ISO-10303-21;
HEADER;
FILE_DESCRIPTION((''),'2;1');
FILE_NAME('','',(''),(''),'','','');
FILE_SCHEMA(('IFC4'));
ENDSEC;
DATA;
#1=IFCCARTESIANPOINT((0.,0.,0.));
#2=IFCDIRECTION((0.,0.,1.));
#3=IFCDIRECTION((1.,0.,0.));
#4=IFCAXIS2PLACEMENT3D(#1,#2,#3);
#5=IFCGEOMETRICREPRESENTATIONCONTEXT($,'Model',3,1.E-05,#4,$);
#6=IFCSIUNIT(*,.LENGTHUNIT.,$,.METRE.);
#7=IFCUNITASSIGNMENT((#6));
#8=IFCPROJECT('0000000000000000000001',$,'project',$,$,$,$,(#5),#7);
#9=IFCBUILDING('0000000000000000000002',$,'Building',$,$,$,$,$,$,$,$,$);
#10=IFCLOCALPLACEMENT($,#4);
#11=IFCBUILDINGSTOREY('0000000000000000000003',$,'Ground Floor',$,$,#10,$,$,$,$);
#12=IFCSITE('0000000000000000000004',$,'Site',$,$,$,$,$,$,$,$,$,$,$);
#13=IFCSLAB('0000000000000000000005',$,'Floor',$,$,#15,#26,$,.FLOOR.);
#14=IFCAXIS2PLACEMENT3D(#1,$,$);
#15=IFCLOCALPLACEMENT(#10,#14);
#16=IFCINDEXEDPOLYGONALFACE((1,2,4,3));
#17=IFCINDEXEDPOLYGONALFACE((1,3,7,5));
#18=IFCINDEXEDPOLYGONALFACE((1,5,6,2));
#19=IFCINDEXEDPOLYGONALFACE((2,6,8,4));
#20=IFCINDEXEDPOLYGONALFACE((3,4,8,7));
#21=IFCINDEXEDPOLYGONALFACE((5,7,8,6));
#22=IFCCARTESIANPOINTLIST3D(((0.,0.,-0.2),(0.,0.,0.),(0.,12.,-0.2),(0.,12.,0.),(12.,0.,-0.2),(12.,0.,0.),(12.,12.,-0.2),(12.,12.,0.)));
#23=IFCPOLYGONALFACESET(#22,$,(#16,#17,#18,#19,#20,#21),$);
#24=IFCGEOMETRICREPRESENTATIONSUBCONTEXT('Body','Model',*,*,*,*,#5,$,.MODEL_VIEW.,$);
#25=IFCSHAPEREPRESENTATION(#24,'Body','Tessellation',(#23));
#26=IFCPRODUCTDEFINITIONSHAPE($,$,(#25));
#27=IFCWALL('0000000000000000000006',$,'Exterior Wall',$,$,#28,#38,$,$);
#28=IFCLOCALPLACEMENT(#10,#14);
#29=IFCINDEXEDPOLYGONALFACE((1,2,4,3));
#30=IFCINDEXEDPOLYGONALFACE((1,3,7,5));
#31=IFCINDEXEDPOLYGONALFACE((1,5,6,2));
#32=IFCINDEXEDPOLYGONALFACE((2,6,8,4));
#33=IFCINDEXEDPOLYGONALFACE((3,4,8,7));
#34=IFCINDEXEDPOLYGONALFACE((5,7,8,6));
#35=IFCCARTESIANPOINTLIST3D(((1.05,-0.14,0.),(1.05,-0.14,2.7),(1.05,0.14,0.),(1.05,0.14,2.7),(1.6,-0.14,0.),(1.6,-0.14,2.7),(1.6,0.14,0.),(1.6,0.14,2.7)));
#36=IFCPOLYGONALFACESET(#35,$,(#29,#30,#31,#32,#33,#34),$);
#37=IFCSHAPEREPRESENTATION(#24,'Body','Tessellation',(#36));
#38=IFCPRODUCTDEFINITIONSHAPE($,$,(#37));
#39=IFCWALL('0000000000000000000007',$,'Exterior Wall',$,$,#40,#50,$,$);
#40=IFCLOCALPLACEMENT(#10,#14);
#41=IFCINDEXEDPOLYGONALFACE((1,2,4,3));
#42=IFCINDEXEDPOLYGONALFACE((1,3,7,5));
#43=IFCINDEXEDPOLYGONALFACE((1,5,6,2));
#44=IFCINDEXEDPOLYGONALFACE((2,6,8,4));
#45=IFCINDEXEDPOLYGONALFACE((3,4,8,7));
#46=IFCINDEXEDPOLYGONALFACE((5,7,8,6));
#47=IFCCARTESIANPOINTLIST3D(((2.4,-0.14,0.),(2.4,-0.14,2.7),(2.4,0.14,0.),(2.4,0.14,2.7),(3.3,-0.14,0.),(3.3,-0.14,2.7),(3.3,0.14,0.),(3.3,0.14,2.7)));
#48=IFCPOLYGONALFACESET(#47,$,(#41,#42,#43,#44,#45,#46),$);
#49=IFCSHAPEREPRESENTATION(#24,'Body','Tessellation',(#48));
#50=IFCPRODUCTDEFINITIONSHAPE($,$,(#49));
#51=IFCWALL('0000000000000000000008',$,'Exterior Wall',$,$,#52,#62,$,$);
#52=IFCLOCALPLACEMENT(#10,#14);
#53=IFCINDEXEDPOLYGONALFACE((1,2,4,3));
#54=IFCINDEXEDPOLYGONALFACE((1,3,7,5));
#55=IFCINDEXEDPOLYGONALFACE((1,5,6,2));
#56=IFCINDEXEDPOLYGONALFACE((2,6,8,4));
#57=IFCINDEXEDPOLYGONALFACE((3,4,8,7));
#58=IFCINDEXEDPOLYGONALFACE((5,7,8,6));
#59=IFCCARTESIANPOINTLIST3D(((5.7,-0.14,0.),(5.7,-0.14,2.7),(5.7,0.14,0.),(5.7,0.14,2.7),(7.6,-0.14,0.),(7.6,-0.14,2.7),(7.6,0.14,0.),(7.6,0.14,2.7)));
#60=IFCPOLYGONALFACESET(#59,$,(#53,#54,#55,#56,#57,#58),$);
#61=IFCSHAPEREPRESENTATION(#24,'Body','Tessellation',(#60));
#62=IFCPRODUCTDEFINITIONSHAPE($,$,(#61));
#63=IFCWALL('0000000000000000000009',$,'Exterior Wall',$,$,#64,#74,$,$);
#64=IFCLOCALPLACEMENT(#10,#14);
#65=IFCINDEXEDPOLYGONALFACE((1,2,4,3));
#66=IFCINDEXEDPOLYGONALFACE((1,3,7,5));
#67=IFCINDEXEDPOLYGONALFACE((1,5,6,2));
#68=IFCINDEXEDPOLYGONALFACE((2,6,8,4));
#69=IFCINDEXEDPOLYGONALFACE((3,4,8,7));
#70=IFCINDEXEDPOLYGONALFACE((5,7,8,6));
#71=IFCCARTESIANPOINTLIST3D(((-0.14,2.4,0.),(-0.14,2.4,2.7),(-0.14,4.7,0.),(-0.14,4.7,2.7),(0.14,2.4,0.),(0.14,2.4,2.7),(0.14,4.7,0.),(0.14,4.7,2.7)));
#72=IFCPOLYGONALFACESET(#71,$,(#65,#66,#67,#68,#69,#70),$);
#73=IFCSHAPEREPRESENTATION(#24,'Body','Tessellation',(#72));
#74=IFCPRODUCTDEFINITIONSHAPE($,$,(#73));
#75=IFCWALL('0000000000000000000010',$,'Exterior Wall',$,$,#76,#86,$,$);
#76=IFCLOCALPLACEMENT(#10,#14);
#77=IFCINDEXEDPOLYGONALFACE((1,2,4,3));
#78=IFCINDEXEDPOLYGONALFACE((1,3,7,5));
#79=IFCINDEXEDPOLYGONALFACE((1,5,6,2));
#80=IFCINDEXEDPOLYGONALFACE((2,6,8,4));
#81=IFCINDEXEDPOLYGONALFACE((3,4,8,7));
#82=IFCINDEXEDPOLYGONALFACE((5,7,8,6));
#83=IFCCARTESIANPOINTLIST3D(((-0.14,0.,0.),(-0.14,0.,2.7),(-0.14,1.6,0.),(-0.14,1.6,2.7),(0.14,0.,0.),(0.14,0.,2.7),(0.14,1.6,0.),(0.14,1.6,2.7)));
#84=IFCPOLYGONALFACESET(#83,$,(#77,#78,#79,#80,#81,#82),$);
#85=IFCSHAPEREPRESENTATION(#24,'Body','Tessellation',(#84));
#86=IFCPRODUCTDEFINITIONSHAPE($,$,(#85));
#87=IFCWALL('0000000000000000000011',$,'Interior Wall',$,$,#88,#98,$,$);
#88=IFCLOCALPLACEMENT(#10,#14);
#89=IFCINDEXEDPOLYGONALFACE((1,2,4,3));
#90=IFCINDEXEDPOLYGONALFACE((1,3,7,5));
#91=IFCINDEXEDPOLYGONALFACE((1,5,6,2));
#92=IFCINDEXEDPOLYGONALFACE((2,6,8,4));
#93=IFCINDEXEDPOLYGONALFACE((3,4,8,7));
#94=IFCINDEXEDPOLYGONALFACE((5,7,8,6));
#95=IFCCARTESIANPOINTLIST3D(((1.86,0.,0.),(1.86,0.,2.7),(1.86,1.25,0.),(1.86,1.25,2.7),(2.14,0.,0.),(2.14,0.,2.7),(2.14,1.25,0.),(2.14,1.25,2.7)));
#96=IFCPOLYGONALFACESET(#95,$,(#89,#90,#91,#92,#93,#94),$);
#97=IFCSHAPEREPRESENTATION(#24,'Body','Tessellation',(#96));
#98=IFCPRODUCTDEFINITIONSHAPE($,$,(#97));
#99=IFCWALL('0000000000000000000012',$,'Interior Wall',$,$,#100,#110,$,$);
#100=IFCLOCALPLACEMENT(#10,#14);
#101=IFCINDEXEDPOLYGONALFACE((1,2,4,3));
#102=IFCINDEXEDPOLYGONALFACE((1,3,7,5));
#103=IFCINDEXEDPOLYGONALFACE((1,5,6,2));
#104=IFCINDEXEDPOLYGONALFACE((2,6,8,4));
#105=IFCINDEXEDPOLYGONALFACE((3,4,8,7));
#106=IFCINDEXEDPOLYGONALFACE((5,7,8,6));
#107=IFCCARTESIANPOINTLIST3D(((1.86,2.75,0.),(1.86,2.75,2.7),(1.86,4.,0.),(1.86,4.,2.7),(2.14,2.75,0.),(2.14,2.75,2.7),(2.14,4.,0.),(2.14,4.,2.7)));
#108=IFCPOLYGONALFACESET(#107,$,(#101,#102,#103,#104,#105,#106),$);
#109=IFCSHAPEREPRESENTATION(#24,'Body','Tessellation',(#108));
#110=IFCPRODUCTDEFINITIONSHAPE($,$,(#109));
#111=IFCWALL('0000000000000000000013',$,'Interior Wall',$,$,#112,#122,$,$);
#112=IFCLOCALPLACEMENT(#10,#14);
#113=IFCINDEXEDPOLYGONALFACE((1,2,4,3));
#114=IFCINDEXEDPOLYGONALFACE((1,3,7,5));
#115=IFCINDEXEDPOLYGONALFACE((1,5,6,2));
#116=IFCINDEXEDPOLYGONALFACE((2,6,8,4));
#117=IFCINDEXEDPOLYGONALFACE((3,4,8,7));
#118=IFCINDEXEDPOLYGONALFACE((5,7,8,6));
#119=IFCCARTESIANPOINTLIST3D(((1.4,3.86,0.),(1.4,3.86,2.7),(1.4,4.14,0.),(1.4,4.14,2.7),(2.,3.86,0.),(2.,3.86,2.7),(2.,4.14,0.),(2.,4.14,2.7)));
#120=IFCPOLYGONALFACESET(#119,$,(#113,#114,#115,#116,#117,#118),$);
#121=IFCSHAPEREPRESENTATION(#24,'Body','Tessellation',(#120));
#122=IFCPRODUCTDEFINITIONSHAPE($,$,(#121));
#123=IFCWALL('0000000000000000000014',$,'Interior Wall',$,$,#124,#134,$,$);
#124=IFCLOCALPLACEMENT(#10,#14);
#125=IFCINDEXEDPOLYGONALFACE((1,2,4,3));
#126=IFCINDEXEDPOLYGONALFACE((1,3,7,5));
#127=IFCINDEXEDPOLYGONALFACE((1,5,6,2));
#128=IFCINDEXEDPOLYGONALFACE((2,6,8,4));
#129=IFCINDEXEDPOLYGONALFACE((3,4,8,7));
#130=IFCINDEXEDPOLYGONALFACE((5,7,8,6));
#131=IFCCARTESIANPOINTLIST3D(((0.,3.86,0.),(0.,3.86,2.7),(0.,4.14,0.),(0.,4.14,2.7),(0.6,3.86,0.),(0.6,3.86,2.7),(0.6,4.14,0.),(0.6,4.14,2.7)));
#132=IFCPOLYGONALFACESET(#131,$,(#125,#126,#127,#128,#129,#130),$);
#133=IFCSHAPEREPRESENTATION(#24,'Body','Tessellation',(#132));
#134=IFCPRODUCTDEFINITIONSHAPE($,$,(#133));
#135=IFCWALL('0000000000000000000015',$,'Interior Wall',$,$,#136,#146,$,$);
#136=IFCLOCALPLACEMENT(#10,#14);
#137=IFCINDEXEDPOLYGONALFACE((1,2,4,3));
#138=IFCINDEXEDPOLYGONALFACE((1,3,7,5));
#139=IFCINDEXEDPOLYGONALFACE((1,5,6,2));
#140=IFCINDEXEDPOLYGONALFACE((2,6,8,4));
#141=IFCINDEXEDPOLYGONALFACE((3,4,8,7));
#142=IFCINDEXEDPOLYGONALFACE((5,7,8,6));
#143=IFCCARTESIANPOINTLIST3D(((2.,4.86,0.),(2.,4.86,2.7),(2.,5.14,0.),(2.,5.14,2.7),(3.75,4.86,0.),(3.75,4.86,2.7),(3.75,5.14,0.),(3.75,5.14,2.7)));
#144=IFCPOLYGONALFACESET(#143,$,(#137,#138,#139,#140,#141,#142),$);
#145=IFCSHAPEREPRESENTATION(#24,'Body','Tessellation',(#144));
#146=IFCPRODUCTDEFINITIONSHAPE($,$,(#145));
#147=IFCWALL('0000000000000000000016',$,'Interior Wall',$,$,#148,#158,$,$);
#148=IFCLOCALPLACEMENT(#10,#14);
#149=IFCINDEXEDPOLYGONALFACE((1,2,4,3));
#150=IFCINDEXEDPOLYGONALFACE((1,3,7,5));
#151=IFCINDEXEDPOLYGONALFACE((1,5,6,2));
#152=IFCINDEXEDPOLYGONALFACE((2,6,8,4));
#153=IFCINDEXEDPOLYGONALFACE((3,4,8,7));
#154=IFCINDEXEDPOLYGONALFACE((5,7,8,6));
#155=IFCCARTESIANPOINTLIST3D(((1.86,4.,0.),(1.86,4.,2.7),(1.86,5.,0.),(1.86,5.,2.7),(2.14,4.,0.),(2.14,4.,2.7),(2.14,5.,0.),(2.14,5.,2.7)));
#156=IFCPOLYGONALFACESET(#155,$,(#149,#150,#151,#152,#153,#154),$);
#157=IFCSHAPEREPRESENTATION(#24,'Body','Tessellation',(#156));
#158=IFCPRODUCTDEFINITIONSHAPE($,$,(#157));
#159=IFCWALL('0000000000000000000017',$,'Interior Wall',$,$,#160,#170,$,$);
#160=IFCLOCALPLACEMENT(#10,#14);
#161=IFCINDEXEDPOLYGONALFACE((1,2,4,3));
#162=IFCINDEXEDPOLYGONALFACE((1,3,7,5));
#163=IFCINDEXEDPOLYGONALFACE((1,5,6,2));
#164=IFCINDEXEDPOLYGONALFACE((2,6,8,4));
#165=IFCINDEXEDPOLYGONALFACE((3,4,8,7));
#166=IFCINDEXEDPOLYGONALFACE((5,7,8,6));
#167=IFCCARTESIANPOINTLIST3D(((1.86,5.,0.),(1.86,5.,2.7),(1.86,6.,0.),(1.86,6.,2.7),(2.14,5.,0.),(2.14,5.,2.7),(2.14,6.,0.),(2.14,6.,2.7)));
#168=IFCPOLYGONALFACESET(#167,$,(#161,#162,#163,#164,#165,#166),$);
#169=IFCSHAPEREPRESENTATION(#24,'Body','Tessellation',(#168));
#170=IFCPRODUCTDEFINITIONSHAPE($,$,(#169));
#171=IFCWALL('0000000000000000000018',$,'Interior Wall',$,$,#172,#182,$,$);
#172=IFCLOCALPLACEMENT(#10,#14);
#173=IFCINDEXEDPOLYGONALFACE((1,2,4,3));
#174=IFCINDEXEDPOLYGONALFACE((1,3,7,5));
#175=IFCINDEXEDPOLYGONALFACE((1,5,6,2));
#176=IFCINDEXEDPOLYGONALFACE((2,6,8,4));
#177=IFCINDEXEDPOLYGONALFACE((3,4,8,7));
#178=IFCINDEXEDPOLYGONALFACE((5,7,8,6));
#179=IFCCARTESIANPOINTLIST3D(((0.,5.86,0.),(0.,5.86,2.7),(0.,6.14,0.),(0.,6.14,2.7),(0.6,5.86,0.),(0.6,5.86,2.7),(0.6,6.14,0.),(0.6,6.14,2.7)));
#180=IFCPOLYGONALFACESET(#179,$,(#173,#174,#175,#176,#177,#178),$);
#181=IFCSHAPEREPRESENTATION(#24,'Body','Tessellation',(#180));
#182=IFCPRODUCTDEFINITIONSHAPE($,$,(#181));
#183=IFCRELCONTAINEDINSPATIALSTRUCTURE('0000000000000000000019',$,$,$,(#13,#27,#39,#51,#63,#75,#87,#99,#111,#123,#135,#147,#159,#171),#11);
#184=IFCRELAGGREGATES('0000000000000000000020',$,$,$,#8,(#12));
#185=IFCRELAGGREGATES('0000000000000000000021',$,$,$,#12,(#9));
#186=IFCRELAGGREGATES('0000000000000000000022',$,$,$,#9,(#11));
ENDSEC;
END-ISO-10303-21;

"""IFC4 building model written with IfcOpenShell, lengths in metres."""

from ifc_helpers import new_model, si_unit, frame, origin_with_axes, place, context, subcontext, project, spatial, indexed_curve, outline, extrude, element, save


model = new_model("IFC4")

# Units and contexts
model_context = context("Model", 3, precision=1e-05, world=origin_with_axes())
body_context = subcontext(model_context, "Body", "Model", "MODEL_VIEW")
ifc_project = project(units=[si_unit("LENGTHUNIT", "METRE")], contexts=[model_context])

# Site, building, storey
site = spatial("IfcSite", under=ifc_project, Name="Site")
building = spatial("IfcBuilding", under=site, Name="Building")
storey_placement = place(None, origin_with_axes())
storey = spatial("IfcBuildingStorey", under=building, at=storey_placement, Name="Ground Floor")

# Slab
slab_placement = place(storey_placement, frame((0.0, 0.0, -0.2), z_axis=(0.0, 0.0, 1.0), x_axis=(1.0, 0.0, 0.0)))
element("IfcSlab", 1, at=slab_placement, inside=storey, Name="Floor", PredefinedType="FLOOR", context=body_context, shape_type="SweptSolid", body=[
    extrude(outline(indexed_curve([(0.0, 0.0), (12.0, 0.0), (12.0, 12.0), (0.0, 12.0)])), None, (0.0, 0.0, 1.0), 0.2),
])

# Walls
wall_1_placement = place(storey_placement, frame((1.05, 0.0, 0.0), z_axis=(0.0, 0.0, 1.0), x_axis=(1.0, 0.0, 0.0)))
element("IfcWall", 2, at=wall_1_placement, inside=storey, Name="Exterior Wall", context=body_context, shape_type="SweptSolid", body=[
    extrude(outline(indexed_curve([(0.0, 0.0), (0.0, 0.28), (0.55, 0.28), (0.55, 0.0), (0.0, 0.0)], self_intersect=False)), frame((0.0, -0.14, 0.0), z_axis=(0.0, 0.0, 1.0), x_axis=(1.0, 0.0, 0.0)), (0.0, 0.0, 1.0), 2.7),
])
wall_2_placement = place(storey_placement, frame((2.4, 0.0, 0.0), z_axis=(0.0, 0.0, 1.0), x_axis=(1.0, 0.0, 0.0)))
element("IfcWall", 3, at=wall_2_placement, inside=storey, Name="Exterior Wall", context=body_context, shape_type="SweptSolid", body=[
    extrude(outline(indexed_curve([(0.0, 0.0), (0.0, 0.28), (0.9, 0.28), (0.9, 0.0), (0.0, 0.0)], self_intersect=False)), frame((0.0, -0.14, 0.0), z_axis=(0.0, 0.0, 1.0), x_axis=(1.0, 0.0, 0.0)), (0.0, 0.0, 1.0), 2.7),
])
wall_3_placement = place(storey_placement, frame((5.7, 0.0, 0.0), z_axis=(0.0, 0.0, 1.0), x_axis=(1.0, 0.0, 0.0)))
element("IfcWall", 4, at=wall_3_placement, inside=storey, Name="Exterior Wall", context=body_context, shape_type="SweptSolid", body=[
    extrude(outline(indexed_curve([(0.0, 0.0), (0.0, 0.28), (1.9, 0.28), (1.9, 0.0), (0.0, 0.0)], self_intersect=False)), frame((0.0, -0.14, 0.0), z_axis=(0.0, 0.0, 1.0), x_axis=(1.0, 0.0, 0.0)), (0.0, 0.0, 1.0), 2.7),
])
wall_4_placement = place(storey_placement, frame((0.0, 4.7, 0.0), z_axis=(0.0, 0.0, 1.0), x_axis=(0.0, -1.0, 0.0)))
element("IfcWall", 5, at=wall_4_placement, inside=storey, Name="Exterior Wall", context=body_context, shape_type="SweptSolid", body=[
    extrude(outline(indexed_curve([(0.0, 0.0), (0.0, 0.28), (2.3, 0.28), (2.3, 0.0), (0.0, 0.0)], self_intersect=False)), frame((0.0, -0.14, 0.0), z_axis=(0.0, 0.0, 1.0), x_axis=(1.0, 0.0, 0.0)), (0.0, 0.0, 1.0), 2.7),
])
wall_5_placement = place(storey_placement, frame((0.0, 1.6, 0.0), z_axis=(0.0, 0.0, 1.0), x_axis=(0.0, -1.0, 0.0)))
element("IfcWall", 6, at=wall_5_placement, inside=storey, Name="Exterior Wall", context=body_context, shape_type="SweptSolid", body=[
    extrude(outline(indexed_curve([(0.0, 0.0), (0.0, 0.28), (1.6, 0.28), (1.6, 0.0), (0.0, 0.0)], self_intersect=False)), frame((0.0, -0.14, 0.0), z_axis=(0.0, 0.0, 1.0), x_axis=(1.0, 0.0, 0.0)), (0.0, 0.0, 1.0), 2.7),
])
for number, where, z_axis, x_axis, name in (
    (7, (2.0, 0.0, 0.0), (0.0, 0.0, 1.0), (0.0, 1.0, 0.0), "Interior Wall"),
    (8, (2.0, 2.75, 0.0), (0.0, 0.0, 1.0), (0.0, 1.0, 0.0), "Interior Wall"),
):
    element("IfcWall", number, at=place(storey_placement, frame(where, z_axis=z_axis, x_axis=x_axis)), inside=storey, Name=name, context=body_context, shape_type="SweptSolid", body=[
        extrude(outline(indexed_curve([(0.0, 0.0), (0.0, 0.28), (1.25, 0.28), (1.25, 0.0), (0.0, 0.0)], self_intersect=False)), frame((0.0, -0.14, 0.0), z_axis=(0.0, 0.0, 1.0), x_axis=(1.0, 0.0, 0.0)), (0.0, 0.0, 1.0), 2.7),
    ])
for number, where, z_axis, x_axis, name in (
    (9, (2.0, 4.0, 0.0), (0.0, 0.0, 1.0), (-1.0, 0.0, 0.0), "Interior Wall"),
    (10, (0.6, 4.0, 0.0), (0.0, 0.0, 1.0), (-1.0, 0.0, 0.0), "Interior Wall"),
):
    element("IfcWall", number, at=place(storey_placement, frame(where, z_axis=z_axis, x_axis=x_axis)), inside=storey, Name=name, context=body_context, shape_type="SweptSolid", body=[
        extrude(outline(indexed_curve([(0.0, 0.0), (0.0, 0.28), (0.6, 0.28), (0.6, 0.0), (0.0, 0.0)], self_intersect=False)), frame((0.0, -0.14, 0.0), z_axis=(0.0, 0.0, 1.0), x_axis=(1.0, 0.0, 0.0)), (0.0, 0.0, 1.0), 2.7),
    ])
wall_6_placement = place(storey_placement, frame((3.75, 5.0, 0.0), z_axis=(0.0, 0.0, 1.0), x_axis=(-1.0, 0.0, 0.0)))
element("IfcWall", 11, at=wall_6_placement, inside=storey, Name="Interior Wall", context=body_context, shape_type="SweptSolid", body=[
    extrude(outline(indexed_curve([(0.0, 0.0), (0.0, 0.28), (1.75, 0.28), (1.75, 0.0), (0.0, 0.0)], self_intersect=False)), frame((0.0, -0.14, 0.0), z_axis=(0.0, 0.0, 1.0), x_axis=(1.0, 0.0, 0.0)), (0.0, 0.0, 1.0), 2.7),
])
for number, where, z_axis, x_axis, name in (
    (12, (2.0, 5.0, 0.0), (0.0, 0.0, 1.0), (0.0, -1.0, 0.0), "Interior Wall"),
    (13, (2.0, 5.0, 0.0), (0.0, 0.0, 1.0), (0.0, 1.0, 0.0), "Interior Wall"),
):
    element("IfcWall", number, at=place(storey_placement, frame(where, z_axis=z_axis, x_axis=x_axis)), inside=storey, Name=name, context=body_context, shape_type="SweptSolid", body=[
        extrude(outline(indexed_curve([(0.0, 0.0), (0.0, 0.28), (1.0, 0.28), (1.0, 0.0), (0.0, 0.0)], self_intersect=False)), frame((0.0, -0.14, 0.0), z_axis=(0.0, 0.0, 1.0), x_axis=(1.0, 0.0, 0.0)), (0.0, 0.0, 1.0), 2.7),
    ])
wall_7_placement = place(storey_placement, frame((0.6, 6.0, 0.0), z_axis=(0.0, 0.0, 1.0), x_axis=(-1.0, 0.0, 0.0)))
element("IfcWall", 14, at=wall_7_placement, inside=storey, Name="Interior Wall", context=body_context, shape_type="SweptSolid", body=[
    extrude(outline(indexed_curve([(0.0, 0.0), (0.0, 0.28), (0.6, 0.28), (0.6, 0.0), (0.0, 0.0)], self_intersect=False)), frame((0.0, -0.14, 0.0), z_axis=(0.0, 0.0, 1.0), x_axis=(1.0, 0.0, 0.0)), (0.0, 0.0, 1.0), 2.7),
])

save(model, "model.ifc")
